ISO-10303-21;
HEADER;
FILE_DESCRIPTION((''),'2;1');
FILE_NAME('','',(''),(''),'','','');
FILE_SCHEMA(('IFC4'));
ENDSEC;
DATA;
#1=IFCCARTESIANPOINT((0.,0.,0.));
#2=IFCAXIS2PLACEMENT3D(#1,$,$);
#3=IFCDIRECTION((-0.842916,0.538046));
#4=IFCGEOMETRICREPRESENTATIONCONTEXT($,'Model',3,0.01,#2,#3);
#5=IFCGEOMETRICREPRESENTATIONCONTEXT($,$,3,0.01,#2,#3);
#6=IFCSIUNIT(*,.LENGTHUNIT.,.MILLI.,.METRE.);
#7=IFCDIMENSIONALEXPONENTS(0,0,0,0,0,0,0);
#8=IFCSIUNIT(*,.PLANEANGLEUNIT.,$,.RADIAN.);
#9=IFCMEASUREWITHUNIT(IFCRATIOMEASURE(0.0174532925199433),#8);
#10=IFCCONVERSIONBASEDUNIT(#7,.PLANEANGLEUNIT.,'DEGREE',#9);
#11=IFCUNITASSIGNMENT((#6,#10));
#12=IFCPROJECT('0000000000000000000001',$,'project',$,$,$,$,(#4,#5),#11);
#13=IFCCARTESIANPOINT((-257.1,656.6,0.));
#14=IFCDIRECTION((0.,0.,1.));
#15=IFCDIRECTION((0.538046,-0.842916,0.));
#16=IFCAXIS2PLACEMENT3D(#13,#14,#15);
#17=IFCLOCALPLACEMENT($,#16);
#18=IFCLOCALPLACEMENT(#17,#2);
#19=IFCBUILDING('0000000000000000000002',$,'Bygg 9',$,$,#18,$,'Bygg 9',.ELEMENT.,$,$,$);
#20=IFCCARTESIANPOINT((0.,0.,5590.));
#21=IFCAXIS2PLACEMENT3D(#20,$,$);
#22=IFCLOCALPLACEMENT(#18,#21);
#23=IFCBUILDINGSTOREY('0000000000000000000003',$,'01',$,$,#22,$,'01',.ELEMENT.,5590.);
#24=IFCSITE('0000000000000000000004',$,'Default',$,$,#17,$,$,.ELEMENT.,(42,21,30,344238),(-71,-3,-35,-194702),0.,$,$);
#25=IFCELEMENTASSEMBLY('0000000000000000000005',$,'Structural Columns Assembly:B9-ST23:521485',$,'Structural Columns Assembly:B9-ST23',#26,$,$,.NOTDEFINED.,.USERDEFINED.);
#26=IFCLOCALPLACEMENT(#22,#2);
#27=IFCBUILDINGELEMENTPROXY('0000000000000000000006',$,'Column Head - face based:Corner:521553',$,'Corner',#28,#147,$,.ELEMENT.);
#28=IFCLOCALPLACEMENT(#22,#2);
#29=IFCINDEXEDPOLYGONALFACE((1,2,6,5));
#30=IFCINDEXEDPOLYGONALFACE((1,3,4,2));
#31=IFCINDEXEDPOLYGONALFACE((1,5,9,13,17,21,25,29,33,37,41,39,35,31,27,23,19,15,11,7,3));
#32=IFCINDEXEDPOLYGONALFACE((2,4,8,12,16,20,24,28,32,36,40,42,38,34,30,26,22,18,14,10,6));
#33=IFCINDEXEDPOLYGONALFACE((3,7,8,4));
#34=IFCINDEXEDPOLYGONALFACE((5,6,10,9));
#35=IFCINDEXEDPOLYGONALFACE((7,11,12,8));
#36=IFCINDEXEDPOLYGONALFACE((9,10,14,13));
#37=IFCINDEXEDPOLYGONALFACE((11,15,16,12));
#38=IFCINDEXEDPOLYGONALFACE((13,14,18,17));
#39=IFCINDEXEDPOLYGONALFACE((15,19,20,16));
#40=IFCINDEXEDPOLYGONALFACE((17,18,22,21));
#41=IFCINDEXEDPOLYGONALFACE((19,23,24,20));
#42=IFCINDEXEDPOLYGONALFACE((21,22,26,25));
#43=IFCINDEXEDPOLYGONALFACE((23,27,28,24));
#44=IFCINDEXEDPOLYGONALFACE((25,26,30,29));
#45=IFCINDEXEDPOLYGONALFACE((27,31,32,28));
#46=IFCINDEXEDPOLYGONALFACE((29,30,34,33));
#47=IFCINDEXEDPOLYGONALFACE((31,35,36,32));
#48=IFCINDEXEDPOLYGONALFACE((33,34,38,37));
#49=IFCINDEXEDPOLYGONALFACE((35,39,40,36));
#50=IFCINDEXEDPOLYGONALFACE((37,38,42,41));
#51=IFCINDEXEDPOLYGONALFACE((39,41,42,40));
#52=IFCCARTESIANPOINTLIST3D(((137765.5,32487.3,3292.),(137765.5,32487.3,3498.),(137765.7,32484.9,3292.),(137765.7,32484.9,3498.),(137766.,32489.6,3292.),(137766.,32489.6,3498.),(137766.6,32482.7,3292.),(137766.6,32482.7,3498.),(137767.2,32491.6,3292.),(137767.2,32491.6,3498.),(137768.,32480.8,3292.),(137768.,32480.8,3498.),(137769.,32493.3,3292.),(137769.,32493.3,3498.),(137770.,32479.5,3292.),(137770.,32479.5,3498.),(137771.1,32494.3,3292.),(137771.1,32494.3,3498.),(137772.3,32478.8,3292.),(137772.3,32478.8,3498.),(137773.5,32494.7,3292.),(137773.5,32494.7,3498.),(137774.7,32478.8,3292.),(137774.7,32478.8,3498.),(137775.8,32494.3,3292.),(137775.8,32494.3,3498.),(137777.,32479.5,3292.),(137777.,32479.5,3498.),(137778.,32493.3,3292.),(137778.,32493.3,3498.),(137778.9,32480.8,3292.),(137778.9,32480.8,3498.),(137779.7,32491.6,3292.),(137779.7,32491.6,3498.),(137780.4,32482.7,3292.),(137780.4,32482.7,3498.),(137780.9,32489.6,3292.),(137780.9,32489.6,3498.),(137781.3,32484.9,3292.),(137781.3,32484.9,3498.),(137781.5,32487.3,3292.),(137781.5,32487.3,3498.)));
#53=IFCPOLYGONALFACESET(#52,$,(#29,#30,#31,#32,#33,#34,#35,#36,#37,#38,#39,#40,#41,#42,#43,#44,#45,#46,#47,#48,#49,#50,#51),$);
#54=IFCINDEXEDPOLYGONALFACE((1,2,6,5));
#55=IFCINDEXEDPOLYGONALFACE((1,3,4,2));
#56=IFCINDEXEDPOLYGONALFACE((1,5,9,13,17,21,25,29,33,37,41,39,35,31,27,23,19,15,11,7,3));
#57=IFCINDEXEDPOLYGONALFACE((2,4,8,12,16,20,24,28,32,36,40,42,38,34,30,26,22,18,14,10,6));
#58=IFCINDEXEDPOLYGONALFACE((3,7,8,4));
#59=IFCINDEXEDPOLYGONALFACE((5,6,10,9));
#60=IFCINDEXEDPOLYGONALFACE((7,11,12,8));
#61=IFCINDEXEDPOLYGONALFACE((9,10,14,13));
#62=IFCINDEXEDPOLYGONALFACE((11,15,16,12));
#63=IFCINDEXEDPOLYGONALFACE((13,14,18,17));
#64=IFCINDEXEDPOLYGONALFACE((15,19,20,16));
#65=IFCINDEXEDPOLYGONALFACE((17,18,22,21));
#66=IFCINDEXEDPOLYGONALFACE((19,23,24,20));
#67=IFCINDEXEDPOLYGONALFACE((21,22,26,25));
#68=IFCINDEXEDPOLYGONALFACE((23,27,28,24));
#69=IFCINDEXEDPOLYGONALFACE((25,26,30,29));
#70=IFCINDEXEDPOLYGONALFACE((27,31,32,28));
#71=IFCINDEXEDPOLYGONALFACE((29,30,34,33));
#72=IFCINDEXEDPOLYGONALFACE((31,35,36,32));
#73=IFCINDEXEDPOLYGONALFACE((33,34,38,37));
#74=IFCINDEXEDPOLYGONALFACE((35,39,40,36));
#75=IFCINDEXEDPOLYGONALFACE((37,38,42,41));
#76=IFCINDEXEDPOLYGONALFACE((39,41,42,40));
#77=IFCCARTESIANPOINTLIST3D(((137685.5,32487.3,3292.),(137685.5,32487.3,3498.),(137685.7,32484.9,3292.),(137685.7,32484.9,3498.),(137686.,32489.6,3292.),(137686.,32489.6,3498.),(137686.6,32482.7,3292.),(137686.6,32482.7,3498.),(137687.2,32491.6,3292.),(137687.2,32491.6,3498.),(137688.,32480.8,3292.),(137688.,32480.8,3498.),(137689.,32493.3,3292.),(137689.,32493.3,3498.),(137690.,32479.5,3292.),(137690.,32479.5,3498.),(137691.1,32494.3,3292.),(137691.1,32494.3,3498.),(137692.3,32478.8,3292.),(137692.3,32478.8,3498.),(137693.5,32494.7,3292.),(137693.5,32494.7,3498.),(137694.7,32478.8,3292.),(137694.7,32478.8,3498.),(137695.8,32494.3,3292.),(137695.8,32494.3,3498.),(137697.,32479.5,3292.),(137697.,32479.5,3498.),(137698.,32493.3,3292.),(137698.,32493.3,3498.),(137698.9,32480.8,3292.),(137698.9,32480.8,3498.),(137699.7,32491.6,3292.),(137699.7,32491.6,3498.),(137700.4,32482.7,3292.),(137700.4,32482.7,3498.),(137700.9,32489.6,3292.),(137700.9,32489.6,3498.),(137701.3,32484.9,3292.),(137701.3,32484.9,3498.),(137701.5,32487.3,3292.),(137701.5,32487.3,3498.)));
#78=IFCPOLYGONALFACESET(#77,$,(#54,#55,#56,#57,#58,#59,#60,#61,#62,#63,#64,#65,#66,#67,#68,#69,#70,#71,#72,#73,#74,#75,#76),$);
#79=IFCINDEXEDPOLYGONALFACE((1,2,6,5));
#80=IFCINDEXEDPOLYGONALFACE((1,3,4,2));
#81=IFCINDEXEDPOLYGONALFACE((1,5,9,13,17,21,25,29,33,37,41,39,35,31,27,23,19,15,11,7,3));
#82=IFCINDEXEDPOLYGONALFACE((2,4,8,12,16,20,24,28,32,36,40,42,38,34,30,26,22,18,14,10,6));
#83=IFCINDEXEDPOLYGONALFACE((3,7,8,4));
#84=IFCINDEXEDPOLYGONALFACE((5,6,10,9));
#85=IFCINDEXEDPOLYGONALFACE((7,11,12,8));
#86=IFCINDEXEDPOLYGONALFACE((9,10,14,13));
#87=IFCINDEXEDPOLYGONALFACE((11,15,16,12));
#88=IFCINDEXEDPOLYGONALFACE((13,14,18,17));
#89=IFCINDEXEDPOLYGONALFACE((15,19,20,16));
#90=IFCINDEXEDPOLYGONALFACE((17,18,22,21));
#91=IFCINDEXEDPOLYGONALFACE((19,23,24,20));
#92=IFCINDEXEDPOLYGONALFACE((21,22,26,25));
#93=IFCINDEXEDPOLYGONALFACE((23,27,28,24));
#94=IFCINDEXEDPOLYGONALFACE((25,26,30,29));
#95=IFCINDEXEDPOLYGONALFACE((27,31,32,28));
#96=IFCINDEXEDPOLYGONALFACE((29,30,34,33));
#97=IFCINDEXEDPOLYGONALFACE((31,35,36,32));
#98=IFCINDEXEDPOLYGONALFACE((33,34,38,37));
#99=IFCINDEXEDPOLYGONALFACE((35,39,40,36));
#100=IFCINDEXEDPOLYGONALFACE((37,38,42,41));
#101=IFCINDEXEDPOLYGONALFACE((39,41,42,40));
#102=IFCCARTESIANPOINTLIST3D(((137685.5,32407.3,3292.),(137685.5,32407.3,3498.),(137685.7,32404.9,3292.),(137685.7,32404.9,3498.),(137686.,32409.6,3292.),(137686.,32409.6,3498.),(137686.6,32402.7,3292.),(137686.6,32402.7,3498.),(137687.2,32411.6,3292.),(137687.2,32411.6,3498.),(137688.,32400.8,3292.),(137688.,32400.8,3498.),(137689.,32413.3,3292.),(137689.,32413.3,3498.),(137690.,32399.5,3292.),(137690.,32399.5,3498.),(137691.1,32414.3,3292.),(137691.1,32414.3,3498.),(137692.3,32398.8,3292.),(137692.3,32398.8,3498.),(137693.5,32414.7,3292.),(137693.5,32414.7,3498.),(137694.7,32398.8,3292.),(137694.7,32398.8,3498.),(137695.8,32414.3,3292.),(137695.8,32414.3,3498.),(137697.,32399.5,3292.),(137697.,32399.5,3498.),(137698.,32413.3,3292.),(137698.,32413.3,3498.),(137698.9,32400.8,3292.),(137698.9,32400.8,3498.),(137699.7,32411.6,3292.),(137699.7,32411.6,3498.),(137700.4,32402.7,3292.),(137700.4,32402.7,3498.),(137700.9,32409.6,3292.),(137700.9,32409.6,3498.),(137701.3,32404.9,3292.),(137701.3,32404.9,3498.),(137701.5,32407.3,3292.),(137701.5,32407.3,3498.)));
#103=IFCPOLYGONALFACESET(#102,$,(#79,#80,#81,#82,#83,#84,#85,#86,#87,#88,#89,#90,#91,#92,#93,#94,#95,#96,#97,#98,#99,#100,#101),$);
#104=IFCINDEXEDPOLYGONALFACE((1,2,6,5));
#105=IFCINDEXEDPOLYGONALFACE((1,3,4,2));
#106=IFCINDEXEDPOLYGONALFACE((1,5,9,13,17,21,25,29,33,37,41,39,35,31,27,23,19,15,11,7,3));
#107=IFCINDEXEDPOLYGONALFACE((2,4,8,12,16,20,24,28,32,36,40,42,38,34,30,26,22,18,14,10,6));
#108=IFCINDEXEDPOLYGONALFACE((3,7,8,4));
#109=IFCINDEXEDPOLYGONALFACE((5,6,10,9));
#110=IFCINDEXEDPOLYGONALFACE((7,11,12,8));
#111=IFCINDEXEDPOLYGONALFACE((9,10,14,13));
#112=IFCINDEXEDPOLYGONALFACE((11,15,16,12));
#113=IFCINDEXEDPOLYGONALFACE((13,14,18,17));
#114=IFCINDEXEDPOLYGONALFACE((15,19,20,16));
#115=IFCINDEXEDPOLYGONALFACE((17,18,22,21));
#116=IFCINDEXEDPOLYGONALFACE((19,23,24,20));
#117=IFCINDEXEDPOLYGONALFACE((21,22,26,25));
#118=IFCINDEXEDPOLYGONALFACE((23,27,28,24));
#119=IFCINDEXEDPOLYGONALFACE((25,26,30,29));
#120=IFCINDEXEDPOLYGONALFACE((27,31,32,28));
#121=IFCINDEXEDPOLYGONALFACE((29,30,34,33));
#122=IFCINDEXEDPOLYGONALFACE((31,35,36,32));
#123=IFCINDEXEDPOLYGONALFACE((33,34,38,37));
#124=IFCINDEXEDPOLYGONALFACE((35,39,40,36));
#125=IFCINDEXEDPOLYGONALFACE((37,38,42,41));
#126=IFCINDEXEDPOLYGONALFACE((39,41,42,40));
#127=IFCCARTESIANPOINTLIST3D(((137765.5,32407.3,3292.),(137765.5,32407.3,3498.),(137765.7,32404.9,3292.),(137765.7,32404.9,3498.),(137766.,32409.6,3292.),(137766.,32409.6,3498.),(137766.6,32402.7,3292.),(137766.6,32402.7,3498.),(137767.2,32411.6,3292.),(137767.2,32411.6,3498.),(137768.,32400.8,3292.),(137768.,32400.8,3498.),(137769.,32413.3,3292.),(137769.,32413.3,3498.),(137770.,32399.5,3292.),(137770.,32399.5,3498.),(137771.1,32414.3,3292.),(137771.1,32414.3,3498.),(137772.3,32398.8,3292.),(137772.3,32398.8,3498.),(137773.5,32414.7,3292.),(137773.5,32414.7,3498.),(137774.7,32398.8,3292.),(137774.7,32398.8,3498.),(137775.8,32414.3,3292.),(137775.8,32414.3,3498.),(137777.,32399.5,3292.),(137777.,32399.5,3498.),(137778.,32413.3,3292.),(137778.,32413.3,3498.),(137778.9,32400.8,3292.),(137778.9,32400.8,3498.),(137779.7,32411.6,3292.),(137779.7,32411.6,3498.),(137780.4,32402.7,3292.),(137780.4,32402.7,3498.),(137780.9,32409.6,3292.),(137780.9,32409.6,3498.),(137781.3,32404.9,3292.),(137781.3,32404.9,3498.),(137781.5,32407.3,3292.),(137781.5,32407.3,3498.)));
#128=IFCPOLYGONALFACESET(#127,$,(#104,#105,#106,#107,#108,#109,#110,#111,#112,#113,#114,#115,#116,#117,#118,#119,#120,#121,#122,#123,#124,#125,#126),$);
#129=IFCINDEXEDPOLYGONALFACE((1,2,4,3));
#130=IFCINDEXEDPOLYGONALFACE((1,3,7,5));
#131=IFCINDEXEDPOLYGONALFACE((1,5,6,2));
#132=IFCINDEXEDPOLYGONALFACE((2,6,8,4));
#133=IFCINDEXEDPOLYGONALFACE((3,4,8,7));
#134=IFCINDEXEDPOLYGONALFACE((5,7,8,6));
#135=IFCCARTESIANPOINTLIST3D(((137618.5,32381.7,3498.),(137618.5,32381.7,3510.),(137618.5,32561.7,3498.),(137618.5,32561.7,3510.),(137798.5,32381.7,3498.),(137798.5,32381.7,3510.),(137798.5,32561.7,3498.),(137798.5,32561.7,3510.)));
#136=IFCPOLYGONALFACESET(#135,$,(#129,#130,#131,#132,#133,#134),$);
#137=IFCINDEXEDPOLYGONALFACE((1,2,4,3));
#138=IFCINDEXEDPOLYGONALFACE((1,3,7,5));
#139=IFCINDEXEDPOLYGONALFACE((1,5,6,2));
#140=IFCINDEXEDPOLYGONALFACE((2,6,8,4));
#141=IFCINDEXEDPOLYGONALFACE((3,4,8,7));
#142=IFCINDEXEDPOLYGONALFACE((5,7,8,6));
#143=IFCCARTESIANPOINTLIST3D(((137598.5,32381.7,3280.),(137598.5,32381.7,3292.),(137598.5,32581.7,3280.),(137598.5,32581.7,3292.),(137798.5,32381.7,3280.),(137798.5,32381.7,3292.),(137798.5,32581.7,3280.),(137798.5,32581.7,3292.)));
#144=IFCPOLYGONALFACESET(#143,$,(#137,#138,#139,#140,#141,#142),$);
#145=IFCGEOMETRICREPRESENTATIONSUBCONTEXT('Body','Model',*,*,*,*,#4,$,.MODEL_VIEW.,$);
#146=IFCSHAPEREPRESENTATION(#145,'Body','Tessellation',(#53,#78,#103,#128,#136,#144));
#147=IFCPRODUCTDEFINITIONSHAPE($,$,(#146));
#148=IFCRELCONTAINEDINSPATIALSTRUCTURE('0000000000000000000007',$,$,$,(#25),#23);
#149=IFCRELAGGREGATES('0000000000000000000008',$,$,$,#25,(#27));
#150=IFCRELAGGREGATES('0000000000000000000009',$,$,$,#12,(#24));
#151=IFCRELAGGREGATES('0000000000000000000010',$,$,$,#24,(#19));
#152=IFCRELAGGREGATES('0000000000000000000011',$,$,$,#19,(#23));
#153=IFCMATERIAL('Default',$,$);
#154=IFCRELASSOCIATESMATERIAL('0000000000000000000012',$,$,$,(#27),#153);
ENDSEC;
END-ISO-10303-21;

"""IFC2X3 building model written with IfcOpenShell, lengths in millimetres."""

from ifc_helpers import new_model, entity, si_unit, converted_unit, direction, frame, frame_2d, origin, origin_2d_with_axis, place, context, subcontext, project, spatial, rectangle, circle, extrude, source, transform, mapped, material, element, aggregate, save


model = new_model("IFC2X3")

# Units and contexts
model_context = context("Model", 3, precision=0.01, world=origin(), true_north=direction((-0.842916, 0.538046)))
context_of_model = context(None, 3, precision=0.01, world=origin(), true_north=direction((-0.842916, 0.538046)))
body_context = subcontext(model_context, "Body", "Model", "MODEL_VIEW")
ifc_project = project(units=[si_unit("LENGTHUNIT", "METRE", prefix="MILLI"), converted_unit("PLANEANGLEUNIT", "DEGREE", entity("IfcRatioMeasure", 0.0174532925199433), si_unit("PLANEANGLEUNIT", "RADIAN"), dimensions=[0, 0, 0, 0, 0, 0, 0])], contexts=[model_context, context_of_model])

# Site, building, storey
site_placement = place(None, frame((-257.1, 656.6, 0.0), z_axis=(0.0, 0.0, 1.0), x_axis=(0.538046, -0.842916, 0.0)))
site = spatial("IfcSite", under=ifc_project, at=site_placement, Name="Default", CompositionType="ELEMENT", RefLatitude=(42, 21, 30, 344238), RefLongitude=(-71, -3, -35, -194702), RefElevation=0.0)
building_placement = place(site_placement, origin())
building = spatial("IfcBuilding", under=site, at=building_placement, Name="Bygg 9", LongName="Bygg 9", CompositionType="ELEMENT")
storey_placement = place(building_placement, frame((0.0, 0.0, 5590.0)))
storey = spatial("IfcBuildingStorey", under=building, at=storey_placement, Name="01", LongName="01", CompositionType="ELEMENT", Elevation=5590.0)

# Element assembly, building element proxy
ifc_material_1 = material(Name="Default")
assembly_1_placement = place(storey_placement, origin())
assembly_1 = element("IfcElementAssembly", 1, at=assembly_1_placement, inside=storey, Name="Structural Columns Assembly:B9-ST23:521485", ObjectType="Structural Columns Assembly:B9-ST23", AssemblyPlace="NOTDEFINED", PredefinedType="USERDEFINED")
shared_shape_1 = source(origin(), body_context, "Body", "SweptSolid", [
    extrude(circle(Radius=8.0, at=frame_2d((0.0, 0.0), x_axis=(1.0, 0.0))), frame((-55.0, -135.0, 12.0)), (0.0, 0.0, 1.0), 206.0),
    extrude(circle(Radius=8.0, at=frame_2d((0.0, 0.0), x_axis=(1.0, 0.0))), frame((-55.0, -55.0, 12.0)), (0.0, 0.0, 1.0), 206.0),
    extrude(circle(Radius=8.0, at=frame_2d((0.0, 0.0), x_axis=(1.0, 0.0))), frame((-135.0, -55.0, 12.0)), (0.0, 0.0, 1.0), 206.0),
    extrude(circle(Radius=8.0, at=frame_2d((0.0, 0.0), x_axis=(1.0, 0.0))), frame((-135.0, -135.0, 12.0)), (0.0, 0.0, 1.0), 206.0),
    extrude(rectangle(XDim=180.0, YDim=180.0, at=origin_2d_with_axis()), frame((-70.0, -70.0, 218.0), z_axis=(0.0, 0.0, 1.0), x_axis=(-1.0, 0.0, 0.0)), (0.0, 0.0, 1.0), 12.0),
    extrude(rectangle(XDim=200.0, YDim=200.0, at=origin_2d_with_axis()), frame((-60.0, -60.0, 0.0), z_axis=(0.0, 0.0, 1.0), x_axis=(0.0, 1.0, 0.0)), (0.0, 0.0, 1.0), 12.0),
])
proxy_1_placement = place(assembly_1_placement, frame((137638.5, 32541.7, 3280.0), z_axis=(0.0, 0.0, 1.0), x_axis=(0.0, 1.0, 0.0)))
proxy_1 = element("IfcBuildingElementProxy", 2, at=proxy_1_placement, material=ifc_material_1, Name="Column Head - face based:Corner:521553", ObjectType="Corner", CompositionType="ELEMENT", context=body_context, shape_type="MappedRepresentation", body=[
    mapped(shared_shape_1, transform((0.0, 0.0, 0.0), scale=1.0)),
])
aggregate(assembly_1, [proxy_1])

save(model, "model.ifc")
